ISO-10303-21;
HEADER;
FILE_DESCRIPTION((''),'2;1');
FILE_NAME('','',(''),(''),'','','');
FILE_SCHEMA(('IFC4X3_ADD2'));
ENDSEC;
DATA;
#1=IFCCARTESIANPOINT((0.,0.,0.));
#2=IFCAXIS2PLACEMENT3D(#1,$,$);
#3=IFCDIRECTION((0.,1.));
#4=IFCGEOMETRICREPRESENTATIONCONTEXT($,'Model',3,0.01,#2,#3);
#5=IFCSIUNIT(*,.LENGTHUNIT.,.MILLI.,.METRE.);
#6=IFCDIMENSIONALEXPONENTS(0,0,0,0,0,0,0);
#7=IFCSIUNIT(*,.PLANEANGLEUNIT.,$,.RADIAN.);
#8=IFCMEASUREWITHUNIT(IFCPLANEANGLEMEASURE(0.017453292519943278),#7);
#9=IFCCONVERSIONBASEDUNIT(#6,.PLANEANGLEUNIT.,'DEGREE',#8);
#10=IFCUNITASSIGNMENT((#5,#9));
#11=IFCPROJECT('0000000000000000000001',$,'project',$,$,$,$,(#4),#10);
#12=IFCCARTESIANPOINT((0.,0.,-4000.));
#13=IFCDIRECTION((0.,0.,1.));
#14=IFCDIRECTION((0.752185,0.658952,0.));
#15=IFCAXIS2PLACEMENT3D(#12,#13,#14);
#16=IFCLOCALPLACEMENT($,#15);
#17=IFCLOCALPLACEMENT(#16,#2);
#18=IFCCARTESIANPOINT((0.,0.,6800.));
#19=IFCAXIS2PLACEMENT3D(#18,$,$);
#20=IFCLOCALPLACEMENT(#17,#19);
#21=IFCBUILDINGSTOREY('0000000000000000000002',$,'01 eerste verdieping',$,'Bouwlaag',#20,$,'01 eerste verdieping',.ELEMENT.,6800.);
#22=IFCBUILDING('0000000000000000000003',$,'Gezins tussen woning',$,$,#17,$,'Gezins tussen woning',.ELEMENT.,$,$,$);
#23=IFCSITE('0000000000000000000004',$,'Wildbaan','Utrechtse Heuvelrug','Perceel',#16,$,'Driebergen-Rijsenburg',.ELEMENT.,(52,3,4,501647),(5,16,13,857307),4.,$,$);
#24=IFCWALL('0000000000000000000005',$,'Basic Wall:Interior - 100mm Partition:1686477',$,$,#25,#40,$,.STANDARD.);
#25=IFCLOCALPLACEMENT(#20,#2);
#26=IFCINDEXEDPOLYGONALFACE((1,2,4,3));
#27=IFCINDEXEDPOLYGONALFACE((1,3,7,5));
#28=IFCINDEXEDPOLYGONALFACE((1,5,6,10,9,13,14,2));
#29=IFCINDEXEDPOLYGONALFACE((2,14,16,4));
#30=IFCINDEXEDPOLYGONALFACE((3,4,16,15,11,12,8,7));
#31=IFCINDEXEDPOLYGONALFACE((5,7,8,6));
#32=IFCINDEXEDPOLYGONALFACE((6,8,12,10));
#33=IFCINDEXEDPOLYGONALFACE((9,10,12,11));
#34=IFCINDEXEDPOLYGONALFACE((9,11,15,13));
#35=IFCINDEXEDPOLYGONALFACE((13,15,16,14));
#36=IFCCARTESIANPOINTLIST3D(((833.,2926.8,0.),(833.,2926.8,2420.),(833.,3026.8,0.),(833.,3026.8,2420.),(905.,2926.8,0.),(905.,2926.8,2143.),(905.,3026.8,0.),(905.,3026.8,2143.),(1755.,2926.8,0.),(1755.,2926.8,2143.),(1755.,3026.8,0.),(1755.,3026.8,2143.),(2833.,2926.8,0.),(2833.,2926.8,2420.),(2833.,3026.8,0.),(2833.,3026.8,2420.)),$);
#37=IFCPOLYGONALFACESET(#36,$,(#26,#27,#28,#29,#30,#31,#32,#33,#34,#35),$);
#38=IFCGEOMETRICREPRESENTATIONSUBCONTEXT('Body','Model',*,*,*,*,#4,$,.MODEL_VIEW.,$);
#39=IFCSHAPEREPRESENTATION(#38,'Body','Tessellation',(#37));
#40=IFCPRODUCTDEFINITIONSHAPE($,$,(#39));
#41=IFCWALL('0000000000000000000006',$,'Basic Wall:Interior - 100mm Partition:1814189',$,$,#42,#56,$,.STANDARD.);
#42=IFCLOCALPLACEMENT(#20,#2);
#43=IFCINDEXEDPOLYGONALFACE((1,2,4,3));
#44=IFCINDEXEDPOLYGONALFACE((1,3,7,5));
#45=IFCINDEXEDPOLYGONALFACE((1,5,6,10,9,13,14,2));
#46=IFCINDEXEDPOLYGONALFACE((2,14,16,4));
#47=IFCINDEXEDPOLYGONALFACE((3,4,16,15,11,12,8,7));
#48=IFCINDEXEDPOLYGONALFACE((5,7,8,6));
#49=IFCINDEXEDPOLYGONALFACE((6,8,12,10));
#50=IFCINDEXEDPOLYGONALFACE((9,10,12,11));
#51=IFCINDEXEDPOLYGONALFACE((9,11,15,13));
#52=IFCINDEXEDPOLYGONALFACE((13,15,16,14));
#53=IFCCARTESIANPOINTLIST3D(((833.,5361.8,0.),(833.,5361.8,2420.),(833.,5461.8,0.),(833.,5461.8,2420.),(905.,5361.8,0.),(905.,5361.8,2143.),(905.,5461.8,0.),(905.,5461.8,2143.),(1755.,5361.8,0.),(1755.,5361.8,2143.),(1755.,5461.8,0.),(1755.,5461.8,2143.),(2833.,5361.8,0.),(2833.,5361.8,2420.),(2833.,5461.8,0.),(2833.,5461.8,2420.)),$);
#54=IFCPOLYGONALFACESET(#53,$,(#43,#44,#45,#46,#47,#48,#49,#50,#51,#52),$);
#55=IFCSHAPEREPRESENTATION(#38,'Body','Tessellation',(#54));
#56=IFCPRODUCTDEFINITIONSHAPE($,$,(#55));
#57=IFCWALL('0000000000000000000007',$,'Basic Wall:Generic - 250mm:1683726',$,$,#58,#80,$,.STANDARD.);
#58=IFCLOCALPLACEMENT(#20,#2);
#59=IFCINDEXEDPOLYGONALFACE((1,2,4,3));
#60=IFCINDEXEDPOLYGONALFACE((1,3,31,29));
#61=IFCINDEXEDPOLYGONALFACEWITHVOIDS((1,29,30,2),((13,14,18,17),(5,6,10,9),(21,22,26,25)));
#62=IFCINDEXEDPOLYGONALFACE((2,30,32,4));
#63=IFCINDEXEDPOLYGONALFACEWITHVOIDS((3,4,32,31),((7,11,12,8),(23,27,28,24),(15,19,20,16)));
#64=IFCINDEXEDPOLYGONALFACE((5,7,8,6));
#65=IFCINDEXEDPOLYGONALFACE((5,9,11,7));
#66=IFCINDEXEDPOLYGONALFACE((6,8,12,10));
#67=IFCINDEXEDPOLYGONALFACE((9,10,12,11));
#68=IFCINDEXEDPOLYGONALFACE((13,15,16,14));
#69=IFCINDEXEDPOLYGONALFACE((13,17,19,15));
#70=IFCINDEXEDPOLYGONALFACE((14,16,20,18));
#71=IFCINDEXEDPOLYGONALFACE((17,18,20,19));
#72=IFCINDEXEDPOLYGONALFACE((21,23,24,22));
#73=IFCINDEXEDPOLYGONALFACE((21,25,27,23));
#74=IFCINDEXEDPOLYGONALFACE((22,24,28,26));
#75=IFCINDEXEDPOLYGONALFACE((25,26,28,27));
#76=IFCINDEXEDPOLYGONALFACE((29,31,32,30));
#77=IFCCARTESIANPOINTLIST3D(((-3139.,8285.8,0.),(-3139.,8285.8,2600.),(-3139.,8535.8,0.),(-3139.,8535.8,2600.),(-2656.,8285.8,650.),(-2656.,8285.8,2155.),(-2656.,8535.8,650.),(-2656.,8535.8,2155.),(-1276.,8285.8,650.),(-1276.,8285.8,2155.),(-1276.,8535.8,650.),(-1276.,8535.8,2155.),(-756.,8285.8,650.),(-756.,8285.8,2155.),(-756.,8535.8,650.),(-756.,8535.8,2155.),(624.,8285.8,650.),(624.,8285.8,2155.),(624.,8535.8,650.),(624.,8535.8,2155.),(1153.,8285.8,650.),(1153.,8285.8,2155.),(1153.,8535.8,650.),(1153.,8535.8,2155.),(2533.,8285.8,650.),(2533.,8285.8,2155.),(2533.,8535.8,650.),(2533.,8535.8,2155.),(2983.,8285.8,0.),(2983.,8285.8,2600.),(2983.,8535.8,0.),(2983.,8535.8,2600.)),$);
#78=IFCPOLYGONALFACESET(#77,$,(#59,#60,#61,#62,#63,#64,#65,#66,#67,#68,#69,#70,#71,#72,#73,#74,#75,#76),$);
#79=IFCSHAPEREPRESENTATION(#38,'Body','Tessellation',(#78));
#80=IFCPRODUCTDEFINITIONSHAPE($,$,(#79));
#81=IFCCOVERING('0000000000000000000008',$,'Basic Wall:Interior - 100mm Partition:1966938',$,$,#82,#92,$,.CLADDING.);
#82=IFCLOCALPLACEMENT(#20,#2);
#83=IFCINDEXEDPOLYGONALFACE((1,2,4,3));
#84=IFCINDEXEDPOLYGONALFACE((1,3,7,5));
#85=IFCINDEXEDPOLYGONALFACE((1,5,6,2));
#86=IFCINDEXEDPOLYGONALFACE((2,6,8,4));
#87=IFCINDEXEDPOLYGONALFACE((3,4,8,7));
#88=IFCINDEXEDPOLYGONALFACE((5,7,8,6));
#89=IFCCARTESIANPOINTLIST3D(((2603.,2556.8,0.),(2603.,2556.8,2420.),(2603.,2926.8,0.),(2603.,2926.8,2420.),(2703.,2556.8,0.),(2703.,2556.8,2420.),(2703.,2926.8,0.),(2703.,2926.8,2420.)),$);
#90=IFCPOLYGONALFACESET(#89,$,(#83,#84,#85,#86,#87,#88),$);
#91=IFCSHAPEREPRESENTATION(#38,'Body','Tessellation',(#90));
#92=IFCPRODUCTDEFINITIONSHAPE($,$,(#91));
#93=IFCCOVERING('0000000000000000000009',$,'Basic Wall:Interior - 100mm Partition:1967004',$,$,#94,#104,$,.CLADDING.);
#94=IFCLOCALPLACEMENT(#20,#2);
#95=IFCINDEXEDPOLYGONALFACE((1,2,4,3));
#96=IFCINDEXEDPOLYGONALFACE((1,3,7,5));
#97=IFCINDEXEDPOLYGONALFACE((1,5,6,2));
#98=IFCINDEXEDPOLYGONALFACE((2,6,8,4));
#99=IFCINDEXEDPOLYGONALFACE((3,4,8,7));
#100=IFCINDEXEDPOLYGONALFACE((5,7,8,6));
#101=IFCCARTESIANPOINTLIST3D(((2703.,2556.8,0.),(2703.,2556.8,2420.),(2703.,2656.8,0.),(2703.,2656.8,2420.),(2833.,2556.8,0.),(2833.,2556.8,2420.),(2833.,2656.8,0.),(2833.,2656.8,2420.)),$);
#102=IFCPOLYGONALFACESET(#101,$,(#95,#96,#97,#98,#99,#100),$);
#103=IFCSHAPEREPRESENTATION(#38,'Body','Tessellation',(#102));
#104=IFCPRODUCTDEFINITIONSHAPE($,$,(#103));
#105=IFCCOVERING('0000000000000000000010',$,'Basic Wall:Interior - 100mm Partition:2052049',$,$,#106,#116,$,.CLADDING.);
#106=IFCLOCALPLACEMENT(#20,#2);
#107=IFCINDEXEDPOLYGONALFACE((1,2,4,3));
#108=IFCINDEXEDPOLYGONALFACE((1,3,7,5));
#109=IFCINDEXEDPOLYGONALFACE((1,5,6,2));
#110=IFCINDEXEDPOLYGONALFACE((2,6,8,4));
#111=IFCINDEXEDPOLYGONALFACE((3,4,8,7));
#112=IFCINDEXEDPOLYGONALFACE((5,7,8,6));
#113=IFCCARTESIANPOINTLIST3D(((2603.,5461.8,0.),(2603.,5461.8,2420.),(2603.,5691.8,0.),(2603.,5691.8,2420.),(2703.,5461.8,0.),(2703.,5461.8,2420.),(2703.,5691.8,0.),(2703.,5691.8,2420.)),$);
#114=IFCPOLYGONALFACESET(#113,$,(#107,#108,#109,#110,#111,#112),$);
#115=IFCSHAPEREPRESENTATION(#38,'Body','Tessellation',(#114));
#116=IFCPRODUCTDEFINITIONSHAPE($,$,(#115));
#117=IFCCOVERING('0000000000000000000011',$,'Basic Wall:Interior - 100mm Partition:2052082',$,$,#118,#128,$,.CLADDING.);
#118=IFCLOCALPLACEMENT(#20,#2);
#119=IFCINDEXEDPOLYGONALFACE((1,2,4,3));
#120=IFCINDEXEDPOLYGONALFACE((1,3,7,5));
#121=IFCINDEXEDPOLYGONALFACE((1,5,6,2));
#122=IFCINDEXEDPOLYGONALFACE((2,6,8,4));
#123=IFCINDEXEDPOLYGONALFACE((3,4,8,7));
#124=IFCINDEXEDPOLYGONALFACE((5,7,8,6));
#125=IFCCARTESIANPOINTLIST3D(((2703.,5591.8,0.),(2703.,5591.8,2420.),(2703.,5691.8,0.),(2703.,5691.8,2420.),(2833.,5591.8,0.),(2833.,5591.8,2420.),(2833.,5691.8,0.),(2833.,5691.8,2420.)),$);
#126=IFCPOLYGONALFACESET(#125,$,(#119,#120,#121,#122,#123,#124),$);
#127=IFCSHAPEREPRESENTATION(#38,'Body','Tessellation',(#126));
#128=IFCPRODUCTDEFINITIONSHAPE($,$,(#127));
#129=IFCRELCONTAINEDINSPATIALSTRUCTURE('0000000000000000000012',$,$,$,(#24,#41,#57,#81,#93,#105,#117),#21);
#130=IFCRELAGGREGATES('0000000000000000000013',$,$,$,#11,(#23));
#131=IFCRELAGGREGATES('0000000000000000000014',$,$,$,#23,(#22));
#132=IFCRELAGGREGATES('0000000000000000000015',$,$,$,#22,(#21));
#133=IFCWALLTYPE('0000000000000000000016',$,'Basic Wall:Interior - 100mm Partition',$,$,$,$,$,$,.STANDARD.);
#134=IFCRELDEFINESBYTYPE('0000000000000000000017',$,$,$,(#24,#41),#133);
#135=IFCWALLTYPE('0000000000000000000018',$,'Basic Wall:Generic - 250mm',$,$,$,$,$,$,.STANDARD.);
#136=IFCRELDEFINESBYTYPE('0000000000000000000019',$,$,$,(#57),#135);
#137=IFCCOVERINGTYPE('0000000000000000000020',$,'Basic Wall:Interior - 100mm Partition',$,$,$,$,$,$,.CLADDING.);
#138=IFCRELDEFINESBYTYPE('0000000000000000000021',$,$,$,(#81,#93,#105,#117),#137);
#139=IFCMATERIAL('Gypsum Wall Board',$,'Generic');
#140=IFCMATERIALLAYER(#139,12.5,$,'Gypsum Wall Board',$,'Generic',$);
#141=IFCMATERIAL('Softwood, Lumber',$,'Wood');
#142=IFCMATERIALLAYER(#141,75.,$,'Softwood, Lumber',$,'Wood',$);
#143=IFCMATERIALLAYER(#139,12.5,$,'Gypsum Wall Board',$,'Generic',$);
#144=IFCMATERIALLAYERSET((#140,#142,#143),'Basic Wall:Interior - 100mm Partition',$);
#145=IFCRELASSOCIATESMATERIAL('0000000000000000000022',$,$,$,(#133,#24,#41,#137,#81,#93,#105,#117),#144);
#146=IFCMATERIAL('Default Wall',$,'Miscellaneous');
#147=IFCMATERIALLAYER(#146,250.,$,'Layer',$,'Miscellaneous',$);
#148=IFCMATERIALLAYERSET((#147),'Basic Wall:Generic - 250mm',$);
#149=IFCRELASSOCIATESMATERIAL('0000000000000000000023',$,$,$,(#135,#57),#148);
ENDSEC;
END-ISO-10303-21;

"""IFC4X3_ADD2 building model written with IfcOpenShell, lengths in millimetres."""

from ifc_helpers import new_model, entity, si_unit, converted_unit, direction, frame, frame_2d, origin, place, context, subcontext, project, spatial, polyline, rectangle, extrude, clip, bounded_halfspace, material, layer, layer_set, layer_usage, type_object, element, save


model = new_model("IFC4X3_ADD2")

# Units and contexts
model_context = context("Model", 3, precision=0.01, world=origin(), true_north=direction((0.0, 1.0)))
body_context = subcontext(model_context, "Body", "Model", "MODEL_VIEW")
ifc_project = project(units=[si_unit("LENGTHUNIT", "METRE", prefix="MILLI"), converted_unit("PLANEANGLEUNIT", "DEGREE", entity("IfcPlaneAngleMeasure", 0.017453292519943278), si_unit("PLANEANGLEUNIT", "RADIAN"), dimensions=[0, 0, 0, 0, 0, 0, 0])], contexts=[model_context])

# Site, building, storey
site_placement = place(None, frame((0.0, 0.0, -4000.0), z_axis=(0.0, 0.0, 1.0), x_axis=(0.752185, 0.658952, 0.0)))
site = spatial("IfcSite", under=ifc_project, at=site_placement, Name="Wildbaan", Description="Utrechtse Heuvelrug", ObjectType="Perceel", LongName="Driebergen-Rijsenburg", CompositionType="ELEMENT", RefLatitude=(52, 3, 4, 501647), RefLongitude=(5, 16, 13, 857307), RefElevation=4.0)
building_placement = place(site_placement, origin())
building = spatial("IfcBuilding", under=site, at=building_placement, Name="Gezins tussen woning", LongName="Gezins tussen woning", CompositionType="ELEMENT")
storey_placement = place(building_placement, frame((0.0, 0.0, 6800.0)))
storey = spatial("IfcBuildingStorey", under=building, at=storey_placement, Name="01 eerste verdieping", ObjectType="Bouwlaag", LongName="01 eerste verdieping", CompositionType="ELEMENT", Elevation=6800.0)

# Walls, openings
ifc_material_1 = material(Name="Gypsum Wall Board", Category="Generic")
ifc_layer_1 = layer(ifc_material_1, 12.5, Name="Gypsum Wall Board", Category="Generic")
ifc_material_2 = material(Name="Softwood, Lumber", Category="Wood")
ifc_layer_2 = layer(ifc_material_2, 75.0, Name="Softwood, Lumber", Category="Wood")
ifc_layer_3 = layer(ifc_material_1, 12.5, Name="Gypsum Wall Board", Category="Generic")
ifc_layer_set_1 = layer_set([ifc_layer_1, ifc_layer_2, ifc_layer_3], Name="Basic Wall:Interior - 100mm Partition")
wall_type_1 = type_object("IfcWallType", Name="Basic Wall:Interior - 100mm Partition", PredefinedType="STANDARD", material=ifc_layer_set_1)
wall_1_placement = place(storey_placement, frame((833.0, 2976.8, 0.0)))
wall_1 = element("IfcWall", 1, at=wall_1_placement, inside=storey, type_object=wall_type_1, material=ifc_layer_set_1, Name="Basic Wall:Interior - 100mm Partition:1686477", PredefinedType="STANDARD", context=body_context, shape_type="Clipping", body=[
    clip(extrude(rectangle(XDim=2000.0, YDim=100.0, at=frame_2d((1000.0, 0.0), x_axis=(-1.0, 0.0))), origin(), (0.0, 0.0, 1.0), 2420.0), bounded_halfspace(frame((0.0, -50.0, 2420.0), z_axis=(0.0, 0.0, -1.0), x_axis=(0.0, -1.0, 0.0)), True, frame((0.0, -50.0, 2420.0)), polyline([(0.0, 0.0), (1770.0, 0.0), (1870.0, 0.0), (2000.0, 0.0), (2000.0, 100.0), (0.0, 100.0), (0.0, 0.0)]))),
])
opening_1_placement = place(wall_1_placement, frame((-833.0, -2976.8, -2.0)))
element("IfcOpeningElement", 2, at=opening_1_placement, cuts=wall_1, PredefinedType="OPENING", context=body_context, shape_type="SweptSolid", body=[
    extrude(rectangle(XDim=2145.0, YDim=850.0, at=frame_2d((0.0, 0.0), x_axis=(1.0, 0.0))), frame((1330.0, 2926.8, 1072.5), z_axis=(0.0, 1.0, 0.0), x_axis=(0.0, 0.0, -1.0)), (0.0, 0.0, 1.0), 100.0),
])
wall_2_placement = place(storey_placement, frame((2833.0, 5411.8, 0.0), z_axis=(0.0, 0.0, 1.0), x_axis=(-1.0, 0.0, 0.0)))
wall_2 = element("IfcWall", 3, at=wall_2_placement, inside=storey, type_object=wall_type_1, material=ifc_layer_set_1, Name="Basic Wall:Interior - 100mm Partition:1814189", PredefinedType="STANDARD", context=body_context, shape_type="SweptSolid", body=[
    extrude(rectangle(XDim=2000.0, YDim=100.0, at=frame_2d((1000.0, 0.0), x_axis=(-1.0, 0.0))), origin(), (0.0, 0.0, 1.0), 2420.0),
])
opening_2_placement = place(wall_2_placement, frame((2833.0, 5411.8, -2.0), z_axis=(0.0, 0.0, 1.0), x_axis=(-1.0, 0.0, 0.0)))
element("IfcOpeningElement", 4, at=opening_2_placement, cuts=wall_2, PredefinedType="OPENING", context=body_context, shape_type="SweptSolid", body=[
    extrude(rectangle(XDim=2145.0, YDim=850.0, at=frame_2d((0.0, 0.0), x_axis=(0.0, 1.0))), frame((1330.0, 5461.8, 1072.5), z_axis=(0.0, -1.0, 0.0), x_axis=(-1.0, 0.0, 0.0)), (0.0, 0.0, 1.0), 100.0),
])

# Wall, openings
ifc_material_3 = material(Name="Default Wall", Category="Miscellaneous")
ifc_layer_4 = layer(ifc_material_3, 250.0, Name="Layer", Category="Miscellaneous")
ifc_layer_set_2 = layer_set([ifc_layer_4], Name="Basic Wall:Generic - 250mm")
wall_type_2 = type_object("IfcWallType", Name="Basic Wall:Generic - 250mm", PredefinedType="STANDARD", material=ifc_layer_set_2)
wall_3_placement = place(storey_placement, frame((-3139.0, 8410.8, 0.0)))
wall_3 = element("IfcWall", 5, at=wall_3_placement, inside=storey, type_object=wall_type_2, material=ifc_layer_set_2, Name="Basic Wall:Generic - 250mm:1683726", PredefinedType="STANDARD", context=body_context, shape_type="SweptSolid", body=[
    extrude(rectangle(XDim=6122.0, YDim=250.0, at=frame_2d((3061.0, 0.0), x_axis=(-1.0, 0.0))), origin(), (0.0, 0.0, 1.0), 2600.0),
])
opening_3_placement = place(wall_3_placement, frame((3139.0, -8410.8, 650.0)))
element("IfcOpeningElement", 6, at=opening_3_placement, cuts=wall_3, PredefinedType="OPENING", context=body_context, shape_type="SweptSolid", body=[
    extrude(rectangle(XDim=1505.0, YDim=1380.0, at=frame_2d((0.0, 0.0), x_axis=(0.0, 1.0))), frame((-1966.0, 8285.8, 752.5), z_axis=(0.0, 1.0, 0.0), x_axis=(1.0, 0.0, 0.0)), (0.0, 0.0, 1.0), 250.0),
])
opening_4_placement = place(wall_3_placement, frame((3139.0, -8410.8, 650.0)))
element("IfcOpeningElement", 7, at=opening_4_placement, cuts=wall_3, PredefinedType="OPENING", context=body_context, shape_type="SweptSolid", body=[
    extrude(rectangle(XDim=1505.0, YDim=1380.0, at=frame_2d((0.0, 0.0), x_axis=(0.0, 1.0))), frame((-66.0, 8285.8, 752.5), z_axis=(0.0, 1.0, 0.0), x_axis=(1.0, 0.0, 0.0)), (0.0, 0.0, 1.0), 250.0),
])
opening_5_placement = place(wall_3_placement, frame((3139.0, -8410.8, 650.0)))
element("IfcOpeningElement", 8, at=opening_5_placement, cuts=wall_3, PredefinedType="OPENING", context=body_context, shape_type="SweptSolid", body=[
    extrude(rectangle(XDim=1505.0, YDim=1380.0, at=frame_2d((0.0, 0.0), x_axis=(0.0, 1.0))), frame((1843.0, 8285.8, 752.5), z_axis=(0.0, 1.0, 0.0), x_axis=(1.0, 0.0, 0.0)), (0.0, 0.0, 1.0), 250.0),
])

# Coverings
ifc_layer_usage_1 = layer_usage(ifc_layer_set_1, "AXIS2", "NEGATIVE", 50.0)
covering_type = type_object("IfcCoveringType", Name="Basic Wall:Interior - 100mm Partition", PredefinedType="CLADDING", material=ifc_layer_set_1)
covering_1_placement = place(storey_placement, frame((2653.0, 2926.8, 0.0), z_axis=(0.0, 0.0, 1.0), x_axis=(0.0, -1.0, 0.0)))
element("IfcCovering", 9, at=covering_1_placement, inside=storey, type_object=covering_type, material=ifc_layer_usage_1, Name="Basic Wall:Interior - 100mm Partition:1966938", PredefinedType="CLADDING", context=body_context, shape_type="SweptSolid", body=[
    extrude(rectangle(XDim=370.0, YDim=100.0, at=frame_2d((185.0, 0.0), x_axis=(-1.0, 0.0))), origin(), (0.0, 0.0, 1.0), 2420.0),
])
ifc_layer_usage_2 = layer_usage(ifc_layer_set_1, "AXIS2", "NEGATIVE", 50.0)
covering_2_placement = place(storey_placement, frame((2703.0, 2606.8, 0.0)))
element("IfcCovering", 10, at=covering_2_placement, inside=storey, type_object=covering_type, material=ifc_layer_usage_2, Name="Basic Wall:Interior - 100mm Partition:1967004", PredefinedType="CLADDING", context=body_context, shape_type="SweptSolid", body=[
    extrude(rectangle(XDim=130.0, YDim=100.0, at=frame_2d((65.0, 0.0), x_axis=(-1.0, 0.0))), origin(), (0.0, 0.0, 1.0), 2420.0),
])
ifc_layer_usage_3 = layer_usage(ifc_layer_set_1, "AXIS2", "NEGATIVE", 50.0)
covering_3_placement = place(storey_placement, frame((2653.0, 5461.8, 0.0), z_axis=(0.0, 0.0, 1.0), x_axis=(0.0, 1.0, 0.0)))
element("IfcCovering", 11, at=covering_3_placement, inside=storey, type_object=covering_type, material=ifc_layer_usage_3, Name="Basic Wall:Interior - 100mm Partition:2052049", PredefinedType="CLADDING", context=body_context, shape_type="SweptSolid", body=[
    extrude(rectangle(XDim=230.0, YDim=100.0, at=frame_2d((115.0, 0.0), x_axis=(-1.0, 0.0))), origin(), (0.0, 0.0, 1.0), 2420.0),
])
ifc_layer_usage_4 = layer_usage(ifc_layer_set_1, "AXIS2", "NEGATIVE", 50.0)
covering_4_placement = place(storey_placement, frame((2703.0, 5641.8, 0.0)))
element("IfcCovering", 12, at=covering_4_placement, inside=storey, type_object=covering_type, material=ifc_layer_usage_4, Name="Basic Wall:Interior - 100mm Partition:2052082", PredefinedType="CLADDING", context=body_context, shape_type="SweptSolid", body=[
    extrude(rectangle(XDim=130.0, YDim=100.0, at=frame_2d((65.0, 0.0), x_axis=(-1.0, 0.0))), origin(), (0.0, 0.0, 1.0), 2420.0),
])

save(model, "model.ifc")
